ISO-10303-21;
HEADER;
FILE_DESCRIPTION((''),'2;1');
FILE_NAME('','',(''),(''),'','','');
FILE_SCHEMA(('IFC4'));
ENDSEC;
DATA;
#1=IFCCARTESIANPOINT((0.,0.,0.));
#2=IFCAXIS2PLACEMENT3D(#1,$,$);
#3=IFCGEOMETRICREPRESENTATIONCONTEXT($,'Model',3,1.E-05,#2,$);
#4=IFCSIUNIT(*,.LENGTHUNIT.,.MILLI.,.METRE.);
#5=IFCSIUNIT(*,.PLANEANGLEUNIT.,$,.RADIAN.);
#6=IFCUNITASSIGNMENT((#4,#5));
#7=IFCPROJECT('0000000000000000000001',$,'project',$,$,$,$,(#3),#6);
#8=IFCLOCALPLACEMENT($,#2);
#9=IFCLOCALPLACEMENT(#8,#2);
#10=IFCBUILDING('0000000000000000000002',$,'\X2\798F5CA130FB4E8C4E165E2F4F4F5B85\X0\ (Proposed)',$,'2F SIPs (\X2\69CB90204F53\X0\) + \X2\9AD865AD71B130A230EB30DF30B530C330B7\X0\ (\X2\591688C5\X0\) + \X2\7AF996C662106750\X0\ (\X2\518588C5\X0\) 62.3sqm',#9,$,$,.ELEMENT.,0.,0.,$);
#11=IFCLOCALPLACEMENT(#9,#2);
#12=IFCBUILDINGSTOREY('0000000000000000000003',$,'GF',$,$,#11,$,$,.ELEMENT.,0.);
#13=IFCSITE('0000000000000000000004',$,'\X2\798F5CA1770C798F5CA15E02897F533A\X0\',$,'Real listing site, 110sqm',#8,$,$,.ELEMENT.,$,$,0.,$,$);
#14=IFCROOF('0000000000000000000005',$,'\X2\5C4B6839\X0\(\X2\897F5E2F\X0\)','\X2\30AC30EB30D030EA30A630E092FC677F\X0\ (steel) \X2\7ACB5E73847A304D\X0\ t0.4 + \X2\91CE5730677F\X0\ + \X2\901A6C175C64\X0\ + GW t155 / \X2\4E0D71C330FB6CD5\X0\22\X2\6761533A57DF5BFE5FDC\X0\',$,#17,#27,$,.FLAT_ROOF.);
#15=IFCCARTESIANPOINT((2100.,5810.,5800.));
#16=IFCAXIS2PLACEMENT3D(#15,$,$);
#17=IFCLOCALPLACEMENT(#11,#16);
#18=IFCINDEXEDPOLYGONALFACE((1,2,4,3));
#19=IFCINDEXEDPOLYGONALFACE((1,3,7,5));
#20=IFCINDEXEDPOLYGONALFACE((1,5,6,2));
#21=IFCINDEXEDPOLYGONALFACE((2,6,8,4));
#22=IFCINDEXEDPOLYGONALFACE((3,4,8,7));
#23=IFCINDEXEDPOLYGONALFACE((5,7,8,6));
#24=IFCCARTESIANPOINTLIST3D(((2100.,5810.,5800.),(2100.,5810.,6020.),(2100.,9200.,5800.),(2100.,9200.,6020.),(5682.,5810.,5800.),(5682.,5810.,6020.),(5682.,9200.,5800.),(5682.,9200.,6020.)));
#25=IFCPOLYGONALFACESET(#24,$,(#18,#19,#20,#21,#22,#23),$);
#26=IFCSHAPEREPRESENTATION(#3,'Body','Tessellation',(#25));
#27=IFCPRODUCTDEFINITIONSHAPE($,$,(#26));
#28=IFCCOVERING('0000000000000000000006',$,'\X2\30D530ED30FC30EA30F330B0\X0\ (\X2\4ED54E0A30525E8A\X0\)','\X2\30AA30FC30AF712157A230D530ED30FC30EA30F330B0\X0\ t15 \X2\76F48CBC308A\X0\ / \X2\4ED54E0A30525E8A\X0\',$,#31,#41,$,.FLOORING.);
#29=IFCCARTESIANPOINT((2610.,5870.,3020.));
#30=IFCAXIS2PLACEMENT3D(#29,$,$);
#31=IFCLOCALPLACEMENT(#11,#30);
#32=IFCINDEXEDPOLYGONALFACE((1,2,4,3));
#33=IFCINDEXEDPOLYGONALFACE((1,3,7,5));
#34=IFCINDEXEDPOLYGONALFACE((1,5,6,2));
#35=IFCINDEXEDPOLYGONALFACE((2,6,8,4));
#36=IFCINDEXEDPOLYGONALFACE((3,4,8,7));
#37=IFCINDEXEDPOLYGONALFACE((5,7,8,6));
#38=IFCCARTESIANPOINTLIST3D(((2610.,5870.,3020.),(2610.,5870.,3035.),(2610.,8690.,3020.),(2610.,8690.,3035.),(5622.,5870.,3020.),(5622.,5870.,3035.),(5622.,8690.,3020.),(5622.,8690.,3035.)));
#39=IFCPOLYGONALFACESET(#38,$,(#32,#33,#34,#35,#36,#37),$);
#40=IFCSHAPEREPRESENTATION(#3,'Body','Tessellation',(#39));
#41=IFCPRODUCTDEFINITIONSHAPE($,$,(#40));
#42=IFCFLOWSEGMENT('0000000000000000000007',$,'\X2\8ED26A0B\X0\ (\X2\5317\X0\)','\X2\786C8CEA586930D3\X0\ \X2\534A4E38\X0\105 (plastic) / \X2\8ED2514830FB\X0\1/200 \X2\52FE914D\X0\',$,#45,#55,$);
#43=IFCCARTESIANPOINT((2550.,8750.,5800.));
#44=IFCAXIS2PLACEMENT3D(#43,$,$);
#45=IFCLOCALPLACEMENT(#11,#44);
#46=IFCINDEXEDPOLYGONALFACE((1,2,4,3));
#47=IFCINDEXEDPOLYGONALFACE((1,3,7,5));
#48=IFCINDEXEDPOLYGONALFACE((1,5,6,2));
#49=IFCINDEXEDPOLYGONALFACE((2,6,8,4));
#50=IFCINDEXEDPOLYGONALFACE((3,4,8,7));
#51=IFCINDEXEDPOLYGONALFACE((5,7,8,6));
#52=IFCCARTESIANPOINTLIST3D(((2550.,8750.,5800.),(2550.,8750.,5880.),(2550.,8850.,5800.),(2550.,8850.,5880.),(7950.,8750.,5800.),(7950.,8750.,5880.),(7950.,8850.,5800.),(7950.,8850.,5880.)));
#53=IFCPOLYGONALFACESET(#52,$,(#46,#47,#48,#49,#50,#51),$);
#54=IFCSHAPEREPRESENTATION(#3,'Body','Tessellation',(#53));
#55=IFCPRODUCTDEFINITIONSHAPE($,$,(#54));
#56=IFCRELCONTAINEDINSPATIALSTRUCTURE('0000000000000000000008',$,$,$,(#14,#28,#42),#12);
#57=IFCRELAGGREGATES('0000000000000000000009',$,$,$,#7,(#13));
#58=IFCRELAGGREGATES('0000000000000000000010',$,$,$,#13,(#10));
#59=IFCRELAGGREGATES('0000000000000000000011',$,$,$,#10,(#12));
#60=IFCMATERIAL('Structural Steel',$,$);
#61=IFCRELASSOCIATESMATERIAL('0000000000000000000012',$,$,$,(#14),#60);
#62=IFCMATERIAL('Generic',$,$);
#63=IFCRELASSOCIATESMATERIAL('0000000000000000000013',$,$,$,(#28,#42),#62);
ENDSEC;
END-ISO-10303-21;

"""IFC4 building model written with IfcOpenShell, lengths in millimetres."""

from ifc_helpers import new_model, si_unit, frame, frame_2d, origin, place, context, project, spatial, rectangle, extrude, material, element, save


model = new_model("IFC4")

# Units and contexts
model_context = context("Model", 3, precision=1e-05, world=origin())
ifc_project = project(units=[si_unit("LENGTHUNIT", "METRE", prefix="MILLI"), si_unit("PLANEANGLEUNIT", "RADIAN")], contexts=[model_context])

# Site, building, storey
site_placement = place(None, origin())
site = spatial("IfcSite", under=ifc_project, at=site_placement, Name="福岡県福岡市西区", ObjectType="Real listing site, 110sqm", CompositionType="ELEMENT", RefElevation=0.0)
building_placement = place(site_placement, origin())
building = spatial("IfcBuilding", under=site, at=building_placement, Name="福岡・二世帯住宅 (Proposed)", ObjectType="2F SIPs (構造体) + 高断熱アルミサッシ (外装) + 竹集成材 (内装) 62.3sqm", CompositionType="ELEMENT", ElevationOfRefHeight=0.0, ElevationOfTerrain=0.0)
storey_placement = place(building_placement, origin())
storey = spatial("IfcBuildingStorey", under=building, at=storey_placement, Name="GF", CompositionType="ELEMENT", Elevation=0.0)

# Roof
ifc_material_1 = material(Name="Structural Steel")
for number, where, name in (
    (1, (2100.0, 5810.0, 5800.0), "屋根(西帯)"),
):
    element("IfcRoof", number, at=place(storey_placement, frame(where)), inside=storey, material=ifc_material_1, Name=name, Description="ガルバリウム鋼板 (steel) 立平葺き t0.4 + 野地板 + 通気層 + GW t155 / 不燃・法22条区域対応", PredefinedType="FLAT_ROOF", context=model_context, shape_type="SweptSolid", body=[
        extrude(rectangle(XDim=3582.0, YDim=3390.0, at=frame_2d((1791.0, 1695.0))), frame((2100.0, 5810.0, 5800.0)), (0.0, 0.0, 1.0), 220.0),
    ])

# Covering
ifc_material_2 = material(Name="Generic")
covering_placement = place(storey_placement, frame((2610.0, 5870.0, 3020.0)))
element("IfcCovering", 2, at=covering_placement, inside=storey, material=ifc_material_2, Name="フローリング (仕上げ床)", Description="オーク無垢フローリング t15 直貼り / 仕上げ床", PredefinedType="FLOORING", context=model_context, shape_type="SweptSolid", body=[
    extrude(rectangle(XDim=3012.0, YDim=2820.0, at=frame_2d((1506.0, 1410.0))), frame((2610.0, 5870.0, 3020.0)), (0.0, 0.0, 1.0), 15.0),
])

# Flow segment
flow_segment_placement = place(storey_placement, frame((2550.0, 8750.0, 5800.0)))
element("IfcFlowSegment", 3, at=flow_segment_placement, inside=storey, material=ifc_material_2, Name="軒樋 (北)", Description="硬質塩ビ 半丸105 (plastic) / 軒先・1/200 勾配", context=model_context, shape_type="SweptSolid", body=[
    extrude(rectangle(XDim=5400.0, YDim=100.0, at=frame_2d((2700.0, 50.0))), frame((2550.0, 8750.0, 5800.0)), (0.0, 0.0, 1.0), 80.0),
])

save(model, "model.ifc")
